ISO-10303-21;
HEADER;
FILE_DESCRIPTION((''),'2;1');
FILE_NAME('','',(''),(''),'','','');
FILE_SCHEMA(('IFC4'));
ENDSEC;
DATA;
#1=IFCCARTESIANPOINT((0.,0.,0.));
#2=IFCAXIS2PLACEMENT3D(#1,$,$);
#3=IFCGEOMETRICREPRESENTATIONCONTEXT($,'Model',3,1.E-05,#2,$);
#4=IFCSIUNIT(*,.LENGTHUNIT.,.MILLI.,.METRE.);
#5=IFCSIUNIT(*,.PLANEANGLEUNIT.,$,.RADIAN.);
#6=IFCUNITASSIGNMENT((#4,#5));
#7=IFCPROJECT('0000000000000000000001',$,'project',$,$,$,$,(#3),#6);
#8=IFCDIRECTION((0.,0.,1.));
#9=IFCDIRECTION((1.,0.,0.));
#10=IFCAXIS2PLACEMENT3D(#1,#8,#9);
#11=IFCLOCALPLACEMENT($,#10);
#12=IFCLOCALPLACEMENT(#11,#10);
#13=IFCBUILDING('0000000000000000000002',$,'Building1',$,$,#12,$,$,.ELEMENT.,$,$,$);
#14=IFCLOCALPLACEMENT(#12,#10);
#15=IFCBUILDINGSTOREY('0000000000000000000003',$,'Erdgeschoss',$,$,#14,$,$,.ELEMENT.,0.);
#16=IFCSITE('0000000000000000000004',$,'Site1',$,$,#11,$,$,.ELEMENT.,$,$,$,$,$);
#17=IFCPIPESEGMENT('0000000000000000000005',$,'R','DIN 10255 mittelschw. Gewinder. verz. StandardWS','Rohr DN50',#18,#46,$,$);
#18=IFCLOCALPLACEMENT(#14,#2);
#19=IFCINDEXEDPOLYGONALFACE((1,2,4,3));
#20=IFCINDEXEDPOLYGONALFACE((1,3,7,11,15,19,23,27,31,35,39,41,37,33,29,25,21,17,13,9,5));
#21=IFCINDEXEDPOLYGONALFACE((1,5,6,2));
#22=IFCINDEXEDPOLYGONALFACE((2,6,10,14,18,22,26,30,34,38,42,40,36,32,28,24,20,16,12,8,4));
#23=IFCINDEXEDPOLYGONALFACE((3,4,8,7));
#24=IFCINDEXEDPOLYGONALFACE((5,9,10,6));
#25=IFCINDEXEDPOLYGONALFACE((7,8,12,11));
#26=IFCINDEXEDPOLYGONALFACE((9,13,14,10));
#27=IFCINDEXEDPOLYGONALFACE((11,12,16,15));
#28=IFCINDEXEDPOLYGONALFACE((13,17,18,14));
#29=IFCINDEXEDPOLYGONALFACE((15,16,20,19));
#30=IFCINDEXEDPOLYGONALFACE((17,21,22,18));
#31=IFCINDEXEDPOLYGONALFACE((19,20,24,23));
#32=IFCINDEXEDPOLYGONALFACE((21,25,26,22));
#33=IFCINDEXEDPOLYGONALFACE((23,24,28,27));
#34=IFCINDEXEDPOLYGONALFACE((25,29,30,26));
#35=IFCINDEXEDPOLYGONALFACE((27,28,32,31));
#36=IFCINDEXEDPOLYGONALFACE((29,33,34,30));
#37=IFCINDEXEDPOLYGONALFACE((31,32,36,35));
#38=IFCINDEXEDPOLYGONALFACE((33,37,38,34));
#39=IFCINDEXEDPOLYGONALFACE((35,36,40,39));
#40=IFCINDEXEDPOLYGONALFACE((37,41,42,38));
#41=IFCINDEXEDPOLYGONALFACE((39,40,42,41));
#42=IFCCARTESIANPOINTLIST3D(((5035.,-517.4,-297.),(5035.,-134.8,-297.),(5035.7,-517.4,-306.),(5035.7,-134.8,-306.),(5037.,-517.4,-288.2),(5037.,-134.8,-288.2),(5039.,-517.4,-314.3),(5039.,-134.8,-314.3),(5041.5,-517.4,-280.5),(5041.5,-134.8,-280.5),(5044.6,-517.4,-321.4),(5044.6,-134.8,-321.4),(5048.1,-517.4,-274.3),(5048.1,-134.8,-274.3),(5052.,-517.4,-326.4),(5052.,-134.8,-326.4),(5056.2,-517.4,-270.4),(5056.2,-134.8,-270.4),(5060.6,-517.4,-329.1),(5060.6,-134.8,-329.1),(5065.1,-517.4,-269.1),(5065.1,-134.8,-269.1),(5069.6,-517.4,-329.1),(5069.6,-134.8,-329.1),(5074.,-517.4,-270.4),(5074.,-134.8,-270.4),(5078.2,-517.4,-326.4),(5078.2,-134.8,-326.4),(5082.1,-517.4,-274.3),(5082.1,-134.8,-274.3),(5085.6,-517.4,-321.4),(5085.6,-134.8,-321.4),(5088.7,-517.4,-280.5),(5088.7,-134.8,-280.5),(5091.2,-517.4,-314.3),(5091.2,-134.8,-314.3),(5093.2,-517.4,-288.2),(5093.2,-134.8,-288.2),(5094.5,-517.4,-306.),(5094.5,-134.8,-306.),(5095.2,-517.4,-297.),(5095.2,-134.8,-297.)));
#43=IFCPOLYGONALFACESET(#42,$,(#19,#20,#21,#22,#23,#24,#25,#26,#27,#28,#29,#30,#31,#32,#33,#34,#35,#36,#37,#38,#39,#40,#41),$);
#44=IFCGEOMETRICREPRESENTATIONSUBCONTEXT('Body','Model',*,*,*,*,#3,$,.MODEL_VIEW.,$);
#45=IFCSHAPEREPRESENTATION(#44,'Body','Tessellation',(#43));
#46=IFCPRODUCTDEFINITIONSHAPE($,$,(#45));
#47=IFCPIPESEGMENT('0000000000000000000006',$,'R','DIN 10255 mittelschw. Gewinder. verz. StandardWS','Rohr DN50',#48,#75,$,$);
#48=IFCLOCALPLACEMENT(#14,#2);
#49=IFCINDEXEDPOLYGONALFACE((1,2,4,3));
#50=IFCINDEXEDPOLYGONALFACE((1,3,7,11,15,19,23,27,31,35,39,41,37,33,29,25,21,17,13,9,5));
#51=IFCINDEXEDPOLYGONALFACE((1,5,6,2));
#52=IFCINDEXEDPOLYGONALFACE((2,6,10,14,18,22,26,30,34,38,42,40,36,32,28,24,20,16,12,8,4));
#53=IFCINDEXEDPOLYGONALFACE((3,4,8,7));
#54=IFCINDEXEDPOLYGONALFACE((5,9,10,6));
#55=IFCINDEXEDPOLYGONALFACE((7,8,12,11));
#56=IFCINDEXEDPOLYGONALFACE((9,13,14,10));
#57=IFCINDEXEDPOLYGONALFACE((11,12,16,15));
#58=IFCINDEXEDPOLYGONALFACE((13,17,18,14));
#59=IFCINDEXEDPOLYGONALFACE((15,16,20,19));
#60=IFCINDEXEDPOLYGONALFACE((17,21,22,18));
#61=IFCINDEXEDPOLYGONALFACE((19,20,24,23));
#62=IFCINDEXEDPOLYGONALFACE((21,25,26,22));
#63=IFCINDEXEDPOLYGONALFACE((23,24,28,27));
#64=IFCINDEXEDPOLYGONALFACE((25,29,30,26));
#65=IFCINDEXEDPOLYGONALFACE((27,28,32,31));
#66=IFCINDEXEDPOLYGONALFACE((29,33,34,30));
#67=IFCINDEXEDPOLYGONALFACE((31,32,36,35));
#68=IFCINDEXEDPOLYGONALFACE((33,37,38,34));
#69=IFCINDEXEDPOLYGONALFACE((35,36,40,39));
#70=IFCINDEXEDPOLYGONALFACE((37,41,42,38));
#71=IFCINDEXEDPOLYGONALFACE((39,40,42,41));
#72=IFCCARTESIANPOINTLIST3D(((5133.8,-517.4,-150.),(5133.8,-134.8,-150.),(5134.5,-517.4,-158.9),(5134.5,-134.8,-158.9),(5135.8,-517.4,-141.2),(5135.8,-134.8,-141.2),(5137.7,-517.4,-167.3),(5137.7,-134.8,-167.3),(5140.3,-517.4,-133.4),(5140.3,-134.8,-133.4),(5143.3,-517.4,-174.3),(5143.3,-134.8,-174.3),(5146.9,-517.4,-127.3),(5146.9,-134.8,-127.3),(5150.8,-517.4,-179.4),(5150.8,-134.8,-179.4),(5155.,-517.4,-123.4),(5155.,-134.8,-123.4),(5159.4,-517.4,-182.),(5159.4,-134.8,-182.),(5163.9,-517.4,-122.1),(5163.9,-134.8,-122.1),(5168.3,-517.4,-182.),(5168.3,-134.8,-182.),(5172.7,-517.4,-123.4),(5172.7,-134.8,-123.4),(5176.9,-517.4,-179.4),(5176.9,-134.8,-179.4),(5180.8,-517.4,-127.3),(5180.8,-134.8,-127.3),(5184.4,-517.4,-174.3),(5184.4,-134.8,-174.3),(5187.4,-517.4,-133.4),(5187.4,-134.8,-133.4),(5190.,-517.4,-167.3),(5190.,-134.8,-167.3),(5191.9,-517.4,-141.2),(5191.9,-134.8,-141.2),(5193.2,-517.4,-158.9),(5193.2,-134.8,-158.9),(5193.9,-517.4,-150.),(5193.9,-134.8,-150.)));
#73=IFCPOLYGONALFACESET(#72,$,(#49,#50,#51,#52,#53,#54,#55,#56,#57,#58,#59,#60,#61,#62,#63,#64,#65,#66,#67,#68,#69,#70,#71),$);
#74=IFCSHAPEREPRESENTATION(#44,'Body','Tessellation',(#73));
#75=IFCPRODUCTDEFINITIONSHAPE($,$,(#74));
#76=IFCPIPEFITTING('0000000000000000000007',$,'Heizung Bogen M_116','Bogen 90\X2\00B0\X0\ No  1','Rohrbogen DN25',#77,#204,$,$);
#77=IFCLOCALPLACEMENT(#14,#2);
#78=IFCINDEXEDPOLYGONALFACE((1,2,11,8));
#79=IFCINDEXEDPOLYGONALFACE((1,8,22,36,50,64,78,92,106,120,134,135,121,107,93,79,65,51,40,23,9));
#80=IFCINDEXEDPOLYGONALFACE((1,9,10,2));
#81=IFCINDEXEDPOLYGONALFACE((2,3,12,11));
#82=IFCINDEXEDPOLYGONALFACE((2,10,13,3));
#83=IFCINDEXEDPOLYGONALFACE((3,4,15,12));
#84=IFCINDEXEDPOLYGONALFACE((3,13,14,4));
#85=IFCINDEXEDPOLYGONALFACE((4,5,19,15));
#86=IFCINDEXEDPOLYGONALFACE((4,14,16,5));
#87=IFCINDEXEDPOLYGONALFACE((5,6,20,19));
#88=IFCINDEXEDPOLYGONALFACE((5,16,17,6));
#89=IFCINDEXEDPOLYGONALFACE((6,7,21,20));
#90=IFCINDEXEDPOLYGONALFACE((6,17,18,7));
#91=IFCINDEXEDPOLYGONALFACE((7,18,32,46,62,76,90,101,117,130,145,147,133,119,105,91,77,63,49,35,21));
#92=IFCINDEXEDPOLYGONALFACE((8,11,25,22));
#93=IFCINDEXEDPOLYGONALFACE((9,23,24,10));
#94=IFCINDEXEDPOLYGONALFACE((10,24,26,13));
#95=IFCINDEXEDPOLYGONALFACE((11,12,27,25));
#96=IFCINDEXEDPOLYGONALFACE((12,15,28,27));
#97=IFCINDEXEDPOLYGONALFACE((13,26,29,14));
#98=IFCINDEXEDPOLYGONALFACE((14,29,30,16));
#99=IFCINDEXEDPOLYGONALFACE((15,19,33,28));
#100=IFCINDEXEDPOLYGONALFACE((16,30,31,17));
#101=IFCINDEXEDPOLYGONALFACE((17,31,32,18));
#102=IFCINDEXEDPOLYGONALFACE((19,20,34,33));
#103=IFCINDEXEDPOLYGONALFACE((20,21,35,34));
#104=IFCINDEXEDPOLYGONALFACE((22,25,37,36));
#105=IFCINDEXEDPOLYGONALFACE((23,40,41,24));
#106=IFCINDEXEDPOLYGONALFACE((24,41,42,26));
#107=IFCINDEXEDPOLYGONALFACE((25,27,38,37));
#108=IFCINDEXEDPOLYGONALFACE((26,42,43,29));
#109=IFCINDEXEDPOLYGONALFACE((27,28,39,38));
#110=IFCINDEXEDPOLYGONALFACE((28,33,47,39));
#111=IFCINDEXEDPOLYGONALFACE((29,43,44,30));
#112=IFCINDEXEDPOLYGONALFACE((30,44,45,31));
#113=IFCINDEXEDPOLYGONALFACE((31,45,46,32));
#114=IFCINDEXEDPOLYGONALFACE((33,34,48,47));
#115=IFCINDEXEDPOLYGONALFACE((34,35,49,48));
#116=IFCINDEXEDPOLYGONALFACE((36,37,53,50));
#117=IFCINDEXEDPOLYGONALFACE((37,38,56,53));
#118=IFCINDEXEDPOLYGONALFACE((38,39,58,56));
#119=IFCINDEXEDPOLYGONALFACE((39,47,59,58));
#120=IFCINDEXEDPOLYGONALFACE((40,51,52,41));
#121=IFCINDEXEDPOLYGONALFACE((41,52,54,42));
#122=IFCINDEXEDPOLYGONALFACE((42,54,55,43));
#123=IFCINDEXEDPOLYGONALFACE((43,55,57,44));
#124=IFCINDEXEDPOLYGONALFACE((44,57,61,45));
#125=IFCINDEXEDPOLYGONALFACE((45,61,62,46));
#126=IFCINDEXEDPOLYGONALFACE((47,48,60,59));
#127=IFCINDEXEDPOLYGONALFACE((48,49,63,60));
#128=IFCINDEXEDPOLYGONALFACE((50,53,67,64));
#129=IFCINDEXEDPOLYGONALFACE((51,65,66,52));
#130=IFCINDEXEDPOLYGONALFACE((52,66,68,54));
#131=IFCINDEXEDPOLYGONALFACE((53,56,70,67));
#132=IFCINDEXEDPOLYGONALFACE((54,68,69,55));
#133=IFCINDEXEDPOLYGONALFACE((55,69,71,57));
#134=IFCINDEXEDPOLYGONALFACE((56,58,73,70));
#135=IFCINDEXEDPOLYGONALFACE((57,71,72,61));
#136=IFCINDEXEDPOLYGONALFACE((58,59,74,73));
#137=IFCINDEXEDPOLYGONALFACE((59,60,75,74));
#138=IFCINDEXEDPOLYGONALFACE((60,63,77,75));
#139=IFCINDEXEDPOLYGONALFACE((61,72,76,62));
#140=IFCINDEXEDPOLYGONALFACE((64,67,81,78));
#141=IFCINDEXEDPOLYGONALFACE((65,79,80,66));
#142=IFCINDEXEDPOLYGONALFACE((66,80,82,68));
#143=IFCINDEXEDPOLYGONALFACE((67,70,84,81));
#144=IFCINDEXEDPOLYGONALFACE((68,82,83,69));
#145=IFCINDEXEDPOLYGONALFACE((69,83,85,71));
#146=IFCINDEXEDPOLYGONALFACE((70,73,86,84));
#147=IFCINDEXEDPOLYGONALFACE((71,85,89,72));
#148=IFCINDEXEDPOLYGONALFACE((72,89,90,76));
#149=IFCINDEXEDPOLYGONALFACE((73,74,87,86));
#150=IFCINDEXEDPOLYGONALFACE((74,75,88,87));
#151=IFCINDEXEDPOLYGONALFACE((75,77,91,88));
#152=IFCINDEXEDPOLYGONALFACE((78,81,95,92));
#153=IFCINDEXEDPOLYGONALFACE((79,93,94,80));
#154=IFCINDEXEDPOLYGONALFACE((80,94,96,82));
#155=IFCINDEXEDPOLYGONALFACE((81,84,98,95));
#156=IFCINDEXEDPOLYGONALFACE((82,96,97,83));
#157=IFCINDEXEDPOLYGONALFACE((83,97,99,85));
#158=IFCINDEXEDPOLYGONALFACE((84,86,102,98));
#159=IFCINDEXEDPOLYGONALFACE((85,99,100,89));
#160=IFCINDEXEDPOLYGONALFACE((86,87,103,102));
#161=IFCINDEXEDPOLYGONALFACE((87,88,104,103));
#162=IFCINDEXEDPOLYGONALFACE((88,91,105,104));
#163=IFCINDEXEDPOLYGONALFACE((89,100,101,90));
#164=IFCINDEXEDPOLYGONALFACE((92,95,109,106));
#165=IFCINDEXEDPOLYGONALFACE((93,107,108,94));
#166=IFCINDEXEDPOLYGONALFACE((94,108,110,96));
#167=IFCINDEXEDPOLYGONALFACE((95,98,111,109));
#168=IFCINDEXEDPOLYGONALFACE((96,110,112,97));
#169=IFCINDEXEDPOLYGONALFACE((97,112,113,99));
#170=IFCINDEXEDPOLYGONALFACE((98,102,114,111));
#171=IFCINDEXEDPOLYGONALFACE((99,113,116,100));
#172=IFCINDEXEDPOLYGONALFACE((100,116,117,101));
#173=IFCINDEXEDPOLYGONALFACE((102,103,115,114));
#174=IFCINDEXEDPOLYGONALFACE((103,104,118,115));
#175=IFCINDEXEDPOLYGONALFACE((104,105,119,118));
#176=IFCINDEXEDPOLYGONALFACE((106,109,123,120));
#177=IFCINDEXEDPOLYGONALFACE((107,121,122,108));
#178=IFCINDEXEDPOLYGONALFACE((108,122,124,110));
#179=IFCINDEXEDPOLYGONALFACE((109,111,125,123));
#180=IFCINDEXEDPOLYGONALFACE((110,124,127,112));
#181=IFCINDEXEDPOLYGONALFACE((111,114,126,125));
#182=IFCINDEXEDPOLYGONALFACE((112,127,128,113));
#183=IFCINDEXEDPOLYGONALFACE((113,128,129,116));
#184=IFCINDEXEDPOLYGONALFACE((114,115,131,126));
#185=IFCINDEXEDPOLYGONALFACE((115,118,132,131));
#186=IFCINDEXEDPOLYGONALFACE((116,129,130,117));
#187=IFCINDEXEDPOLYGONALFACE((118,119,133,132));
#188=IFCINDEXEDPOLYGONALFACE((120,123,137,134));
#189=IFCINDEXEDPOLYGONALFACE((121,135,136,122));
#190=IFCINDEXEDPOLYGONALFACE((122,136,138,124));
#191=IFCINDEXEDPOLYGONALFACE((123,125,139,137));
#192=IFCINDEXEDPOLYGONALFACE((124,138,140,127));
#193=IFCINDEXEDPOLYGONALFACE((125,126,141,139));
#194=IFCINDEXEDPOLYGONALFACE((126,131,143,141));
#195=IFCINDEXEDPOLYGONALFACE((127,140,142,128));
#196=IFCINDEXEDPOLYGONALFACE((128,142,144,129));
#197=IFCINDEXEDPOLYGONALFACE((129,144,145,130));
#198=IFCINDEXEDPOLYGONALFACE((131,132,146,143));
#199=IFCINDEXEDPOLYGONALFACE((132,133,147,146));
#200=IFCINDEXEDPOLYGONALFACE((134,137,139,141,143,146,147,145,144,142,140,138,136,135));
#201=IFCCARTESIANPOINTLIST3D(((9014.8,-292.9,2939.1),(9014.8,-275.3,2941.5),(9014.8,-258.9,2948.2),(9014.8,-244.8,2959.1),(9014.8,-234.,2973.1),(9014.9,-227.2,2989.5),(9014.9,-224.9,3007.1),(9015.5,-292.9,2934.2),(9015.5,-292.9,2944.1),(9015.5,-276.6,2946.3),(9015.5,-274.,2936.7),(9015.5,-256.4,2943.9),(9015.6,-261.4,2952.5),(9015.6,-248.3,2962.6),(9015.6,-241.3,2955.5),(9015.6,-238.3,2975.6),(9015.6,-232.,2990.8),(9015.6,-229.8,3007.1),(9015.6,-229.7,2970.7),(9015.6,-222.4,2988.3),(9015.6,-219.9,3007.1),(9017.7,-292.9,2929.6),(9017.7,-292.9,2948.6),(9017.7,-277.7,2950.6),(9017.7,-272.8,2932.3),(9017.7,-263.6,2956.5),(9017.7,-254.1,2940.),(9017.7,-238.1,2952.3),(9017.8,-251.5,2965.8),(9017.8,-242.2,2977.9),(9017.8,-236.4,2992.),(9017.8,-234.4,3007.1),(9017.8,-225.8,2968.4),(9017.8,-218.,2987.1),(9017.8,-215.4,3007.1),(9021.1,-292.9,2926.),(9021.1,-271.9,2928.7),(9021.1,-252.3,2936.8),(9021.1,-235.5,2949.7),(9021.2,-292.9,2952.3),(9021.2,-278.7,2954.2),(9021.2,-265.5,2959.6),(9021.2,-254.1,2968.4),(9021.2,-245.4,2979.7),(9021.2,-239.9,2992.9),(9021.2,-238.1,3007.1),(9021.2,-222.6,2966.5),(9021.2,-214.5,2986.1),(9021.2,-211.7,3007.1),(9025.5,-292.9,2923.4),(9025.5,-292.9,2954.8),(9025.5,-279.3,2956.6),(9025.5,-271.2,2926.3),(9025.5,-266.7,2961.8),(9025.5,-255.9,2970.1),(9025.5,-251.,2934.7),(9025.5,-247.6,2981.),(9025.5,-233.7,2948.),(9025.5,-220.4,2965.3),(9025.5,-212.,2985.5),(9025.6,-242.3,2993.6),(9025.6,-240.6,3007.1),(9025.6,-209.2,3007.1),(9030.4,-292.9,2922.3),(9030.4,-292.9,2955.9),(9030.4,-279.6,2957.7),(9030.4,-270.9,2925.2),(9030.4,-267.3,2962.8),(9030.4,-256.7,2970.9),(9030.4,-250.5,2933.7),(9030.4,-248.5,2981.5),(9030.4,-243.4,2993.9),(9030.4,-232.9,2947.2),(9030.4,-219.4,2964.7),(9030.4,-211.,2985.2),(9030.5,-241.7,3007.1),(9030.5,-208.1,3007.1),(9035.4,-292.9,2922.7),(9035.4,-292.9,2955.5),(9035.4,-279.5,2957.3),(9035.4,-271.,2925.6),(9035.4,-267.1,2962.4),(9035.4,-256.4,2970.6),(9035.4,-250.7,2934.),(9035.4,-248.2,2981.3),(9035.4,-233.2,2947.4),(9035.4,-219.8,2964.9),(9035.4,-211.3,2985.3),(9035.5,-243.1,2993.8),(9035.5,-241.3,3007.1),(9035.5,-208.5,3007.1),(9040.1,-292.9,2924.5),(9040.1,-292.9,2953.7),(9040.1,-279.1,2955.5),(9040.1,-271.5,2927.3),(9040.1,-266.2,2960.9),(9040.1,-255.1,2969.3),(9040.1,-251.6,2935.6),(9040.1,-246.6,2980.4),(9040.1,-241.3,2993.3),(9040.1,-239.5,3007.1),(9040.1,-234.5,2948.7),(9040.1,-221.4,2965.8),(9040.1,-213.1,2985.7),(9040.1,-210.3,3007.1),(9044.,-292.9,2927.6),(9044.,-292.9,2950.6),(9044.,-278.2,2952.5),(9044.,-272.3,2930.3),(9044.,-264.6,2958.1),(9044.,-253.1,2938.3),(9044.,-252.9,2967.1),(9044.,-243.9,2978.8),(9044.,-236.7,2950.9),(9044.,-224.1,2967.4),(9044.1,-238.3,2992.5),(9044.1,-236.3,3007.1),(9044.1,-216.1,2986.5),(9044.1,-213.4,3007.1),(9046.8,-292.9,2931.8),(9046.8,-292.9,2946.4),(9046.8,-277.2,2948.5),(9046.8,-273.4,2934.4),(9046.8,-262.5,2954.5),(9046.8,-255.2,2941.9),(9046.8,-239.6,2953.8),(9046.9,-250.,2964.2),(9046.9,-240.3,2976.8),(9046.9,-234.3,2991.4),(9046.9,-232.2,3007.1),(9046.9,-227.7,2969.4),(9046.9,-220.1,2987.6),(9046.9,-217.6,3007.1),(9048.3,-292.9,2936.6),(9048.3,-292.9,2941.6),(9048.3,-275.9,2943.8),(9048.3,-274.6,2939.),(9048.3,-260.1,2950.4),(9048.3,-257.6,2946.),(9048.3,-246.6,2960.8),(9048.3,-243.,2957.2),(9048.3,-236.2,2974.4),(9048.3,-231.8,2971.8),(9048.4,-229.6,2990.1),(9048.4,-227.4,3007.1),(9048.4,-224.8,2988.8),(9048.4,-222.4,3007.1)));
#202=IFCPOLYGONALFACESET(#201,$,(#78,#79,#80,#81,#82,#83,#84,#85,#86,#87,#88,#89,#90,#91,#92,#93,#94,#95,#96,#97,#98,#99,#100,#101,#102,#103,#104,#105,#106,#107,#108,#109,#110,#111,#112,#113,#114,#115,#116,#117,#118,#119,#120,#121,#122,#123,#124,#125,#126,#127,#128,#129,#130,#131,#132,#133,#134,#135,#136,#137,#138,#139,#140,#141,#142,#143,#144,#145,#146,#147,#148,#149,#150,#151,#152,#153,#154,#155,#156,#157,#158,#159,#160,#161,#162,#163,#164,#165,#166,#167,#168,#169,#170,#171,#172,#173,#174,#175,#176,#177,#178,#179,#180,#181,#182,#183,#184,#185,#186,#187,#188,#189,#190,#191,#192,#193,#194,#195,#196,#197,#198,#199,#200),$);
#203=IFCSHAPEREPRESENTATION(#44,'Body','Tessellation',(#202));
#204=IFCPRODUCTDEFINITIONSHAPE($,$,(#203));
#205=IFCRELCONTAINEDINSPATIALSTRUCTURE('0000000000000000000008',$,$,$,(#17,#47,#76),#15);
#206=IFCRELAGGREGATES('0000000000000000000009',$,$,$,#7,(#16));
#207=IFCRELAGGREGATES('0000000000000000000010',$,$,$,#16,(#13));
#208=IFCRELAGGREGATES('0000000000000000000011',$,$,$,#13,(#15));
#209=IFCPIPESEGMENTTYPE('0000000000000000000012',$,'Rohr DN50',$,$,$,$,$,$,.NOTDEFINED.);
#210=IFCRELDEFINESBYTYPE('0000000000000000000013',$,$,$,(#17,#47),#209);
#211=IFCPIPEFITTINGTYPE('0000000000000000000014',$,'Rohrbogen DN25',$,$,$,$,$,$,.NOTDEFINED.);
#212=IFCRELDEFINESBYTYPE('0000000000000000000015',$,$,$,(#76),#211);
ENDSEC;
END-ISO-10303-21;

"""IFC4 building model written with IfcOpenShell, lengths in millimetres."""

from ifc_helpers import new_model, entity, si_unit, frame, origin, origin_with_axes, origin_2d_with_axis, place, context, subcontext, project, spatial, circle, extrude, source, transform, mapped, type_object, element, save


model = new_model("IFC4")

# Units and contexts
model_context = context("Model", 3, precision=1e-05, world=origin())
body_context = subcontext(model_context, "Body", "Model", "MODEL_VIEW")
ifc_project = project(units=[si_unit("LENGTHUNIT", "METRE", prefix="MILLI"), si_unit("PLANEANGLEUNIT", "RADIAN")], contexts=[model_context])

# Site, building, storey
site_placement = place(None, origin_with_axes())
site = spatial("IfcSite", under=ifc_project, at=site_placement, Name="Site1", CompositionType="ELEMENT")
building_placement = place(site_placement, origin_with_axes())
building = spatial("IfcBuilding", under=site, at=building_placement, Name="Building1", CompositionType="ELEMENT")
storey_placement = place(building_placement, origin_with_axes())
storey = spatial("IfcBuildingStorey", under=building, at=storey_placement, Name="Erdgeschoss", CompositionType="ELEMENT", Elevation=0.0)

# Pipe segments
pipe_segment_type_1 = type_object("IfcPipeSegmentType", Name="Rohr DN50", PredefinedType="NOTDEFINED")
pipe_segment_1_placement = place(storey_placement, frame((5065.0, -326.1, -299.2), z_axis=(0.0, 0.0, 1.0), x_axis=(1.0, 0.0, 0.0)))
element("IfcPipeSegment", 1, at=pipe_segment_1_placement, inside=storey, type_object=pipe_segment_type_1, Name="R", Description="DIN 10255 mittelschw. Gewinder. verz. StandardWS", ObjectType="Rohr DN50", context=body_context, shape_type="SolidModel", body=[
    extrude(circle(Radius=30.1, at=origin_2d_with_axis()), frame((0.1, -191.3, 0.0), z_axis=(0.0, 1.0, 0.0), x_axis=(0.0, 0.0, 1.0)), (0.0, 0.0, 1.0), 382.6),
])
pipe_segment_2_placement = place(storey_placement, frame((5163.7, -326.1, -152.2), z_axis=(0.0, 0.0, 1.0), x_axis=(1.0, 0.0, 0.0)))
element("IfcPipeSegment", 2, at=pipe_segment_2_placement, inside=storey, type_object=pipe_segment_type_1, Name="R", Description="DIN 10255 mittelschw. Gewinder. verz. StandardWS", ObjectType="Rohr DN50", context=body_context, shape_type="SolidModel", body=[
    extrude(circle(Radius=30.1, at=origin_2d_with_axis()), frame((0.1, -191.3, 0.0), z_axis=(0.0, 1.0, 0.0), x_axis=(0.0, 0.0, 1.0)), (0.0, 0.0, 1.0), 382.6),
])

# Pipe fitting
pipe_fitting_type_1 = type_object("IfcPipeFittingType", Name="Rohrbogen DN25", PredefinedType="NOTDEFINED")
shared_shape_1 = source(origin_with_axes(), body_context, "Body", "SolidModel", [
    entity("IfcRevolvedAreaSolid", entity("IfcCircleProfileDef", "AREA", None, entity("IfcAxis2Placement2D", entity("IfcCartesianPoint", [0.0, 0.0]), entity("IfcDirection", [1.0, 0.0])), 16.9), entity("IfcAxis2Placement3D", entity("IfcCartesianPoint", [-42.4, 0.0, -25.6]), entity("IfcDirection", [1.0, 0.0, 0.0]), entity("IfcDirection", [0.0, 0.999999, 0.001207])), entity("IfcAxis1Placement", entity("IfcCartesianPoint", [0.0, 68.0, 0.0]), entity("IfcDirection", [-1.0, 0.0, 0.0])), 1.570796),
])
pipe_fitting_1_placement = place(storey_placement, frame((9031.7, -250.5, 2964.7), z_axis=(0.0, 0.0, 1.0), x_axis=(1.0, 0.0, 0.0)))
element("IfcPipeFitting", 3, at=pipe_fitting_1_placement, inside=storey, type_object=pipe_fitting_type_1, Name="Heizung Bogen M_116", Description="Bogen 90° No  1", ObjectType="Rohrbogen DN25", context=body_context, shape_type="MappedRepresentation", body=[
    mapped(shared_shape_1, transform((0.0, 0.0, 0.0), x_axis=(0.0, 1.0, 0.0), y_axis=(-1.0, 0.0, 0.0), z_axis=(0.0, 0.0, 1.0), scale=1.0)),
])

save(model, "model.ifc")
